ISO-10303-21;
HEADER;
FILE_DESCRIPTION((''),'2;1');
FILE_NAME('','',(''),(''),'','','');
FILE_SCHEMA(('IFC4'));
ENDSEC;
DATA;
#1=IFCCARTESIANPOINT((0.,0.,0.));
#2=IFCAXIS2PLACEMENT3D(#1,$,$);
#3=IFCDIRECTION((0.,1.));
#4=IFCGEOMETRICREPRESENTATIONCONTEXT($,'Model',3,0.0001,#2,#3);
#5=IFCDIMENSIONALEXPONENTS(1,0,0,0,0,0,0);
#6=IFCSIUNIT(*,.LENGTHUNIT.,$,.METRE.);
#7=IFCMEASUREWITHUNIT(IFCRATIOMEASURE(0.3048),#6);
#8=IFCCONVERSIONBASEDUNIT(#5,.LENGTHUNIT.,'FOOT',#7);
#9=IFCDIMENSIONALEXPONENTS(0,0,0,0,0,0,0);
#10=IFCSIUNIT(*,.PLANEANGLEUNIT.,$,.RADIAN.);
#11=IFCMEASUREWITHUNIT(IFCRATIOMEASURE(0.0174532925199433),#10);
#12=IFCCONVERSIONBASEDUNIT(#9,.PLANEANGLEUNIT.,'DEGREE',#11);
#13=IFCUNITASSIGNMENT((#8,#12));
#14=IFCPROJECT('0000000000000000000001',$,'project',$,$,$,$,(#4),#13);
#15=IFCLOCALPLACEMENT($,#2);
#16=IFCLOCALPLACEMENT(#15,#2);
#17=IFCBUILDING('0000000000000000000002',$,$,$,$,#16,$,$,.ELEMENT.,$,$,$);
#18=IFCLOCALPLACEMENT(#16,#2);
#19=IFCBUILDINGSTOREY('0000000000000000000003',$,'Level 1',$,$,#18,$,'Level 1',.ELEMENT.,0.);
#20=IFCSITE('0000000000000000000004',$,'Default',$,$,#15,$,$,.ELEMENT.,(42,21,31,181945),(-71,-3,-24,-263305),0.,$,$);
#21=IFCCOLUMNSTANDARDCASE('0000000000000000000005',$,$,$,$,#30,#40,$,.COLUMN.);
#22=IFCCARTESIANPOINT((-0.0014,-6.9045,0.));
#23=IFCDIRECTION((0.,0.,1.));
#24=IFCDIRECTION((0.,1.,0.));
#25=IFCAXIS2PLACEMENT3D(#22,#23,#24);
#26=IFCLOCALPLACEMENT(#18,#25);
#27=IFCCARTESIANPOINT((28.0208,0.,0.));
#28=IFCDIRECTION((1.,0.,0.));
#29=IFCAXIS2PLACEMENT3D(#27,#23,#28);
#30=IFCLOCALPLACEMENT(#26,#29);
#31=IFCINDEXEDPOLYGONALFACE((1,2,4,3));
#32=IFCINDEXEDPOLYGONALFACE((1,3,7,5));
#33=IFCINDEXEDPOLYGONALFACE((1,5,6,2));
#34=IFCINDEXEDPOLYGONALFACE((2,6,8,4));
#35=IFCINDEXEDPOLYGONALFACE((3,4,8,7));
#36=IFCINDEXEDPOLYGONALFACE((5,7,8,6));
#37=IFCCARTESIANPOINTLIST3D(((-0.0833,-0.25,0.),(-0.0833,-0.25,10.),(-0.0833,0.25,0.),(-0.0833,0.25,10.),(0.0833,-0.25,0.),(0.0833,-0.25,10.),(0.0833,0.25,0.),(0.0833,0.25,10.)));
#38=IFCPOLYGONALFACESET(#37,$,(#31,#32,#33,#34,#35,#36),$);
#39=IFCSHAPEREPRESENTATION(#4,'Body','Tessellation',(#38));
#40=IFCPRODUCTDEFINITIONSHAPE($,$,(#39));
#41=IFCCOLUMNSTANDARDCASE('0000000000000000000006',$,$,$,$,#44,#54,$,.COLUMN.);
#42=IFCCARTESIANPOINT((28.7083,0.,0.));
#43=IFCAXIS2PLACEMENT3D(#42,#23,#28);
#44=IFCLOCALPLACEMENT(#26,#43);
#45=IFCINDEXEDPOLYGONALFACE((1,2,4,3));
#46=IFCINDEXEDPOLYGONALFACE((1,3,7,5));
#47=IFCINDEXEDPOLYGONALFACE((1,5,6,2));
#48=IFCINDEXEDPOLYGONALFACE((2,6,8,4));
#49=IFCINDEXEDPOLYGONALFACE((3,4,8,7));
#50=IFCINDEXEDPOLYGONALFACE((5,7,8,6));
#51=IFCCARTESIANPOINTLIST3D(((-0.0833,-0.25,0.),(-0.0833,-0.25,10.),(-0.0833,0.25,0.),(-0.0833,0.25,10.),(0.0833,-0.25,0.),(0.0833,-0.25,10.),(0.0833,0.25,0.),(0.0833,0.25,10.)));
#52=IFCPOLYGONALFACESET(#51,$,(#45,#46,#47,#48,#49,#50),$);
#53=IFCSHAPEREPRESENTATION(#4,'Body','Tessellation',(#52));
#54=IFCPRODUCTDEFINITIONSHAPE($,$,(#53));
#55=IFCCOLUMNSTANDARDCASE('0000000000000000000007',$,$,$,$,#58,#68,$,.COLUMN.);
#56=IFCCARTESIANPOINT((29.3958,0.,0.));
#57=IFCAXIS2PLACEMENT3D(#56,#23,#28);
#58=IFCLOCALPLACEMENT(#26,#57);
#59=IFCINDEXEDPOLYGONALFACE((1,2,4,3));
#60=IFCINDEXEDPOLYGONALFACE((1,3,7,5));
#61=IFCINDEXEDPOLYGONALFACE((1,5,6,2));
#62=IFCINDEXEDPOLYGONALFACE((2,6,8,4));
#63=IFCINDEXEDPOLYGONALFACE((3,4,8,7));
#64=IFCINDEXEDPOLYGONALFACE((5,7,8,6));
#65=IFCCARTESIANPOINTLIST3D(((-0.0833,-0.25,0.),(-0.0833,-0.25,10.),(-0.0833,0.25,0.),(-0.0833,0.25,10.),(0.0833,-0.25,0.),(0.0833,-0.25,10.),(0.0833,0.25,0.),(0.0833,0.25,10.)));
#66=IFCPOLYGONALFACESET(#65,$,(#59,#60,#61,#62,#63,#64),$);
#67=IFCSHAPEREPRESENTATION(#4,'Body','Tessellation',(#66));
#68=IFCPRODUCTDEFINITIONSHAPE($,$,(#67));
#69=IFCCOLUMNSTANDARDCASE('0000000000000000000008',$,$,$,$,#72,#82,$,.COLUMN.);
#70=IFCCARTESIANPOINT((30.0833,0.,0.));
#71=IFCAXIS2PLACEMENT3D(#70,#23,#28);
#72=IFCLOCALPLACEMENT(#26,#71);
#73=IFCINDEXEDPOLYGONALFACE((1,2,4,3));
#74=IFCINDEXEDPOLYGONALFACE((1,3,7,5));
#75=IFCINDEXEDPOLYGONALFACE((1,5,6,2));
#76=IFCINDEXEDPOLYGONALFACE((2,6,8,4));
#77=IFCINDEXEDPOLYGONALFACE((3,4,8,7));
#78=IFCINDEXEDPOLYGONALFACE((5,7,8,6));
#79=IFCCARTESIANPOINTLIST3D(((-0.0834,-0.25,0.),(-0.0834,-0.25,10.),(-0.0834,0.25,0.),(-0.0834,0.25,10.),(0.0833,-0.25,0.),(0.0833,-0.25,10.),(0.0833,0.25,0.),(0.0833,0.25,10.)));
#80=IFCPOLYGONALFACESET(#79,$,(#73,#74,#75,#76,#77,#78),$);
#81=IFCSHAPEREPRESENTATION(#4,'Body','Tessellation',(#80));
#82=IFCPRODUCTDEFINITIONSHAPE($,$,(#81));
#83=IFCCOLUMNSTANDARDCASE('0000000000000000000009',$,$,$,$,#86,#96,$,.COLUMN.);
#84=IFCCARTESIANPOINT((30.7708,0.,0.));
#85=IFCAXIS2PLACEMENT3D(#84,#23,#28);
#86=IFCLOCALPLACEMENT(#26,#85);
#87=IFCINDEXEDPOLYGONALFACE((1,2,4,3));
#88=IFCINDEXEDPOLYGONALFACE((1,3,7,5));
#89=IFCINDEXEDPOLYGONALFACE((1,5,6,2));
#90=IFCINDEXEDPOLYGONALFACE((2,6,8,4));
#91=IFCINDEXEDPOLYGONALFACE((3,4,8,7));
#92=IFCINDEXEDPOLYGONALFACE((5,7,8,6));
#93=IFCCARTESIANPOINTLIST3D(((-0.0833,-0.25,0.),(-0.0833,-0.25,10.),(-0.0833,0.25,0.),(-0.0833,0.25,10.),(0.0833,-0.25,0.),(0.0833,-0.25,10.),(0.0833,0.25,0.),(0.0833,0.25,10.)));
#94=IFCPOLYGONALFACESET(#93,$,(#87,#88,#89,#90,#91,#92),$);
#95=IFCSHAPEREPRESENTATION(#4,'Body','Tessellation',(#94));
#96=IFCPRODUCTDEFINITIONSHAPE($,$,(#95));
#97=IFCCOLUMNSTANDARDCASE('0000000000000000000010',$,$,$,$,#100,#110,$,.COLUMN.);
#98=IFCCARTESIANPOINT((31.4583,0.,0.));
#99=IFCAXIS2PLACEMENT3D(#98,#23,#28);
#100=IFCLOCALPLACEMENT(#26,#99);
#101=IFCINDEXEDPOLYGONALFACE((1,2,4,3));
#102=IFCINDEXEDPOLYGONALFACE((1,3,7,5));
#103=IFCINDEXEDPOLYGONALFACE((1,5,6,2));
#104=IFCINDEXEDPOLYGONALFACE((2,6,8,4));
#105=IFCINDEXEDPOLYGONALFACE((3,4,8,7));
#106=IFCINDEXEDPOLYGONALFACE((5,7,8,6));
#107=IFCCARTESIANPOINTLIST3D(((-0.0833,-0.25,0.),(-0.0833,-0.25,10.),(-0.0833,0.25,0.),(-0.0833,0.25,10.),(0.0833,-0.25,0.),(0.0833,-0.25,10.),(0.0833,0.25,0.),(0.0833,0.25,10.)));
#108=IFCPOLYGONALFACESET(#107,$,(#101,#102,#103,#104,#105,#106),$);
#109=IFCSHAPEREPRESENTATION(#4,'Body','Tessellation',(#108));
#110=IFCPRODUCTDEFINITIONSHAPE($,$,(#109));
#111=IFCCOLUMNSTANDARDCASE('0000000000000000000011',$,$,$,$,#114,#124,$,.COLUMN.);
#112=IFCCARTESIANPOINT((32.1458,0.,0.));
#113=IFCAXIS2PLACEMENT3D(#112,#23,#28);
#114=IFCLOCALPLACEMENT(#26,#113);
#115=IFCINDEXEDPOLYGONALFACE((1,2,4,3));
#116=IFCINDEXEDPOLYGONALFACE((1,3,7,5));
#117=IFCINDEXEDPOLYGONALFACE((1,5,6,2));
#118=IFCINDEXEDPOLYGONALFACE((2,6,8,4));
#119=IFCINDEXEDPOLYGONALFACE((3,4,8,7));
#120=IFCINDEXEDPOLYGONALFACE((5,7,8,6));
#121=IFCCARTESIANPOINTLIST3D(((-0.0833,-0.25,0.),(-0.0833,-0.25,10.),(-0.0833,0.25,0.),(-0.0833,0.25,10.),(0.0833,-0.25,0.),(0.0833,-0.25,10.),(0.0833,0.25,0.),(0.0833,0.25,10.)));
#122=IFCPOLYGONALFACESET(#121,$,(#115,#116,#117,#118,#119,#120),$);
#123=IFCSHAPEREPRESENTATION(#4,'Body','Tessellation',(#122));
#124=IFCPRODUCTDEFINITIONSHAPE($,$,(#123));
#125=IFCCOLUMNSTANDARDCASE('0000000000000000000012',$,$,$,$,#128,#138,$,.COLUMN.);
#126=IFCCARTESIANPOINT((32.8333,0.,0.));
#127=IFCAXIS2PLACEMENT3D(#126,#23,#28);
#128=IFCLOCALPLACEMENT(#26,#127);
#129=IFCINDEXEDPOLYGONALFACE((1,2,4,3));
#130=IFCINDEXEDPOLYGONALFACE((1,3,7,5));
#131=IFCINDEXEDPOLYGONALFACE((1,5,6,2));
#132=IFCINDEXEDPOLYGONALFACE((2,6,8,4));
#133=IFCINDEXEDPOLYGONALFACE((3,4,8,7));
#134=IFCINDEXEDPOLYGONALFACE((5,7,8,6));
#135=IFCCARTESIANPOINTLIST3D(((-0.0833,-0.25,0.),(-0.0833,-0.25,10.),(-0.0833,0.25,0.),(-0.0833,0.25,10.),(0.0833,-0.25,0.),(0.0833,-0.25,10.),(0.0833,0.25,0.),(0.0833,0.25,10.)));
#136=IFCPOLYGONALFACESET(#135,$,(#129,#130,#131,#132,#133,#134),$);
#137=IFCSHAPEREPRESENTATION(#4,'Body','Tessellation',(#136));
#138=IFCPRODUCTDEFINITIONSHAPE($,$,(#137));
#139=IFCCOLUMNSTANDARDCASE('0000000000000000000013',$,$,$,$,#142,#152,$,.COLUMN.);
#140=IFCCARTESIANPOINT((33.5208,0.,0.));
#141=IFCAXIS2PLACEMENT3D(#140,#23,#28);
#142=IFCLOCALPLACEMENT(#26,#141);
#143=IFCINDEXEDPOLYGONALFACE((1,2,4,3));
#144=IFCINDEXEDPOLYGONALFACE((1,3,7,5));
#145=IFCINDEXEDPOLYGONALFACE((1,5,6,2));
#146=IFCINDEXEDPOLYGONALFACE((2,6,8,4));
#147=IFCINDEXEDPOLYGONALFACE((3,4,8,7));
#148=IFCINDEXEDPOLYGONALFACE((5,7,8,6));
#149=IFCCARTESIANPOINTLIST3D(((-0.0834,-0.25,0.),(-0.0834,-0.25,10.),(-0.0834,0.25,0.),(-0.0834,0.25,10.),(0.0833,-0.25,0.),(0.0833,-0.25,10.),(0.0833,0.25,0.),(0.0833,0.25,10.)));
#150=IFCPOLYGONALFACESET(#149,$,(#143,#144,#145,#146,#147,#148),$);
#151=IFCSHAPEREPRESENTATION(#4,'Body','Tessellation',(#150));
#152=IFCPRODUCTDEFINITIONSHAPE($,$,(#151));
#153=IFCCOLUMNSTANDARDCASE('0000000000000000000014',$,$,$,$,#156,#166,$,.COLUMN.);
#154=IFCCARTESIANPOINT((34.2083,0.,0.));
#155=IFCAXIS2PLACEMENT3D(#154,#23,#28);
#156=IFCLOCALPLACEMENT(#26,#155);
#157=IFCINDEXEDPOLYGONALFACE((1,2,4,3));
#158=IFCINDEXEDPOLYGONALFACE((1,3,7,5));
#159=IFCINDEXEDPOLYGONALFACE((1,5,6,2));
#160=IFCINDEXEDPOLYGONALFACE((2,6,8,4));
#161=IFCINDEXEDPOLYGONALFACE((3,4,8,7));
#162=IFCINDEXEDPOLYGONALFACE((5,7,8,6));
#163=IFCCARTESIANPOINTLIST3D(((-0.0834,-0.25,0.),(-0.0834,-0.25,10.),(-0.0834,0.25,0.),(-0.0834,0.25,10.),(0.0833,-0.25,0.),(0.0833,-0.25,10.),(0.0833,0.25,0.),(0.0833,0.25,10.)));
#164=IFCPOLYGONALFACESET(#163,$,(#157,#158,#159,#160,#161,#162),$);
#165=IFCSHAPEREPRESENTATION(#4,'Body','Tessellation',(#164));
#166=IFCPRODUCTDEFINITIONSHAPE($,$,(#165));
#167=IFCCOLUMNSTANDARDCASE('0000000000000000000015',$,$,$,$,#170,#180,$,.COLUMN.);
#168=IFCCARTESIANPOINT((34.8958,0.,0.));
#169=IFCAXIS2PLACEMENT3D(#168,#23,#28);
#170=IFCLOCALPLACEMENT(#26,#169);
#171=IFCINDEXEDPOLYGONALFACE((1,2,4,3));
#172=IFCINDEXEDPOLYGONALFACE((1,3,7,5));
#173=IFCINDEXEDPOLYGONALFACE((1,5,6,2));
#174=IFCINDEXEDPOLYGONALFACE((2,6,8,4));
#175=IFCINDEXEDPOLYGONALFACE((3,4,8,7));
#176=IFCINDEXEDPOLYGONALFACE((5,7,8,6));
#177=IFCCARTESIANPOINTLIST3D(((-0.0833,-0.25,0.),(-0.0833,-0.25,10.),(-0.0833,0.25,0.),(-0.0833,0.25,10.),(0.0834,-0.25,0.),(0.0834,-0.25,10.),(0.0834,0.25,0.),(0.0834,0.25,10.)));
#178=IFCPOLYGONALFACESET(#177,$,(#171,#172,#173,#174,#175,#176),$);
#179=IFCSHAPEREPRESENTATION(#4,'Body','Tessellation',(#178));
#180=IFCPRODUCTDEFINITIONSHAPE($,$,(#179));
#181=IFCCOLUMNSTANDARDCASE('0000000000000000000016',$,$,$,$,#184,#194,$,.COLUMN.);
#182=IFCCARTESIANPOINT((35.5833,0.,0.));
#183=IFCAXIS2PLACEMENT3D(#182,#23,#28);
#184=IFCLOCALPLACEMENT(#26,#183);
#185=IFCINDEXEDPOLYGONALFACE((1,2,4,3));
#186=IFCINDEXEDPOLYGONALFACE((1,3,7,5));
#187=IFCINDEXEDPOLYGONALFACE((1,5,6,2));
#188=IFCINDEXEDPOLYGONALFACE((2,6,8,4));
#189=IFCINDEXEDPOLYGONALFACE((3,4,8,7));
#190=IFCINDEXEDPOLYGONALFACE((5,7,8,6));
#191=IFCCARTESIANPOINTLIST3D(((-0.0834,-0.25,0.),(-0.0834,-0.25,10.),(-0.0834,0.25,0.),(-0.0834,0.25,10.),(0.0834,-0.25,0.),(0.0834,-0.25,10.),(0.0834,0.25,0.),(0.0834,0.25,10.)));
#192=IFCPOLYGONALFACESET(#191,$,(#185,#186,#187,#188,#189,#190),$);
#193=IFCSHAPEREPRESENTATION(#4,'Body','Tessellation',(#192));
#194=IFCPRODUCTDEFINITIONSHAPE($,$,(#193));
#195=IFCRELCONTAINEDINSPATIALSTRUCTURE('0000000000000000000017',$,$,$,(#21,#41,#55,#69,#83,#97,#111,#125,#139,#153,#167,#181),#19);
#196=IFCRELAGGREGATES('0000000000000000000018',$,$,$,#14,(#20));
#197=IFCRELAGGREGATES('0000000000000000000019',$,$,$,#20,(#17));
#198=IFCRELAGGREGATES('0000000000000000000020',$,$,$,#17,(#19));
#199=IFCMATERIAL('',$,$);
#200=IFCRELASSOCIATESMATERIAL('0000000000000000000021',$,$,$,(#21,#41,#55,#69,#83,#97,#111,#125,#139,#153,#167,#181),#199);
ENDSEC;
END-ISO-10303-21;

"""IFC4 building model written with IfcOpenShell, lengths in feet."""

from ifc_helpers import new_model, entity, si_unit, converted_unit, direction, frame, origin, place, context, project, spatial, rectangle, extrude, material, element, save


model = new_model("IFC4")

# Units and contexts
model_context = context("Model", 3, precision=0.0001, world=origin(), true_north=direction((0.0, 1.0)))
ifc_project = project(units=[converted_unit("LENGTHUNIT", "FOOT", entity("IfcRatioMeasure", 0.3048), si_unit("LENGTHUNIT", "METRE"), dimensions=[1, 0, 0, 0, 0, 0, 0]), converted_unit("PLANEANGLEUNIT", "DEGREE", entity("IfcRatioMeasure", 0.0174532925199433), si_unit("PLANEANGLEUNIT", "RADIAN"), dimensions=[0, 0, 0, 0, 0, 0, 0])], contexts=[model_context])

# Site, building, storey
site_placement = place(None, origin())
site = spatial("IfcSite", under=ifc_project, at=site_placement, Name="Default", CompositionType="ELEMENT", RefLatitude=(42, 21, 31, 181945), RefLongitude=(-71, -3, -24, -263305), RefElevation=0.0)
building_placement = place(site_placement, origin())
building = spatial("IfcBuilding", under=site, at=building_placement, CompositionType="ELEMENT")
storey_placement = place(building_placement, origin())
storey = spatial("IfcBuildingStorey", under=building, at=storey_placement, Name="Level 1", LongName="Level 1", CompositionType="ELEMENT", Elevation=0.0)

# Columns
ifc_material_1 = material(Name="")
placement = place(storey_placement, frame((-0.0014, -6.9045, 0.0), z_axis=(0.0, 0.0, 1.0), x_axis=(0.0, 1.0, 0.0)))
for number, where, z_axis, x_axis in (
    (1, (28.0208, 0.0, 0.0), (0.0, 0.0, 1.0), (1.0, 0.0, 0.0)),
    (2, (28.7083, 0.0, 0.0), (0.0, 0.0, 1.0), (1.0, 0.0, 0.0)),
    (3, (29.3958, 0.0, 0.0), (0.0, 0.0, 1.0), (1.0, 0.0, 0.0)),
    (4, (30.0833, 0.0, 0.0), (0.0, 0.0, 1.0), (1.0, 0.0, 0.0)),
    (5, (30.7708, 0.0, 0.0), (0.0, 0.0, 1.0), (1.0, 0.0, 0.0)),
    (6, (31.4583, 0.0, 0.0), (0.0, 0.0, 1.0), (1.0, 0.0, 0.0)),
    (7, (32.1458, 0.0, 0.0), (0.0, 0.0, 1.0), (1.0, 0.0, 0.0)),
    (8, (32.8333, 0.0, 0.0), (0.0, 0.0, 1.0), (1.0, 0.0, 0.0)),
    (9, (33.5208, 0.0, 0.0), (0.0, 0.0, 1.0), (1.0, 0.0, 0.0)),
    (10, (34.2083, 0.0, 0.0), (0.0, 0.0, 1.0), (1.0, 0.0, 0.0)),
    (11, (34.8958, 0.0, 0.0), (0.0, 0.0, 1.0), (1.0, 0.0, 0.0)),
    (12, (35.5833, 0.0, 0.0), (0.0, 0.0, 1.0), (1.0, 0.0, 0.0)),
):
    element("IfcColumnStandardCase", number, at=place(placement, frame(where, z_axis=z_axis, x_axis=x_axis)), inside=storey, material=ifc_material_1, PredefinedType="COLUMN", context=model_context, shape_type="SweptSolid", body=[
        extrude(rectangle(XDim=0.1667, YDim=0.5), origin(), (0.0, 0.0, 1.0), 10.0),
    ])

save(model, "model.ifc")
